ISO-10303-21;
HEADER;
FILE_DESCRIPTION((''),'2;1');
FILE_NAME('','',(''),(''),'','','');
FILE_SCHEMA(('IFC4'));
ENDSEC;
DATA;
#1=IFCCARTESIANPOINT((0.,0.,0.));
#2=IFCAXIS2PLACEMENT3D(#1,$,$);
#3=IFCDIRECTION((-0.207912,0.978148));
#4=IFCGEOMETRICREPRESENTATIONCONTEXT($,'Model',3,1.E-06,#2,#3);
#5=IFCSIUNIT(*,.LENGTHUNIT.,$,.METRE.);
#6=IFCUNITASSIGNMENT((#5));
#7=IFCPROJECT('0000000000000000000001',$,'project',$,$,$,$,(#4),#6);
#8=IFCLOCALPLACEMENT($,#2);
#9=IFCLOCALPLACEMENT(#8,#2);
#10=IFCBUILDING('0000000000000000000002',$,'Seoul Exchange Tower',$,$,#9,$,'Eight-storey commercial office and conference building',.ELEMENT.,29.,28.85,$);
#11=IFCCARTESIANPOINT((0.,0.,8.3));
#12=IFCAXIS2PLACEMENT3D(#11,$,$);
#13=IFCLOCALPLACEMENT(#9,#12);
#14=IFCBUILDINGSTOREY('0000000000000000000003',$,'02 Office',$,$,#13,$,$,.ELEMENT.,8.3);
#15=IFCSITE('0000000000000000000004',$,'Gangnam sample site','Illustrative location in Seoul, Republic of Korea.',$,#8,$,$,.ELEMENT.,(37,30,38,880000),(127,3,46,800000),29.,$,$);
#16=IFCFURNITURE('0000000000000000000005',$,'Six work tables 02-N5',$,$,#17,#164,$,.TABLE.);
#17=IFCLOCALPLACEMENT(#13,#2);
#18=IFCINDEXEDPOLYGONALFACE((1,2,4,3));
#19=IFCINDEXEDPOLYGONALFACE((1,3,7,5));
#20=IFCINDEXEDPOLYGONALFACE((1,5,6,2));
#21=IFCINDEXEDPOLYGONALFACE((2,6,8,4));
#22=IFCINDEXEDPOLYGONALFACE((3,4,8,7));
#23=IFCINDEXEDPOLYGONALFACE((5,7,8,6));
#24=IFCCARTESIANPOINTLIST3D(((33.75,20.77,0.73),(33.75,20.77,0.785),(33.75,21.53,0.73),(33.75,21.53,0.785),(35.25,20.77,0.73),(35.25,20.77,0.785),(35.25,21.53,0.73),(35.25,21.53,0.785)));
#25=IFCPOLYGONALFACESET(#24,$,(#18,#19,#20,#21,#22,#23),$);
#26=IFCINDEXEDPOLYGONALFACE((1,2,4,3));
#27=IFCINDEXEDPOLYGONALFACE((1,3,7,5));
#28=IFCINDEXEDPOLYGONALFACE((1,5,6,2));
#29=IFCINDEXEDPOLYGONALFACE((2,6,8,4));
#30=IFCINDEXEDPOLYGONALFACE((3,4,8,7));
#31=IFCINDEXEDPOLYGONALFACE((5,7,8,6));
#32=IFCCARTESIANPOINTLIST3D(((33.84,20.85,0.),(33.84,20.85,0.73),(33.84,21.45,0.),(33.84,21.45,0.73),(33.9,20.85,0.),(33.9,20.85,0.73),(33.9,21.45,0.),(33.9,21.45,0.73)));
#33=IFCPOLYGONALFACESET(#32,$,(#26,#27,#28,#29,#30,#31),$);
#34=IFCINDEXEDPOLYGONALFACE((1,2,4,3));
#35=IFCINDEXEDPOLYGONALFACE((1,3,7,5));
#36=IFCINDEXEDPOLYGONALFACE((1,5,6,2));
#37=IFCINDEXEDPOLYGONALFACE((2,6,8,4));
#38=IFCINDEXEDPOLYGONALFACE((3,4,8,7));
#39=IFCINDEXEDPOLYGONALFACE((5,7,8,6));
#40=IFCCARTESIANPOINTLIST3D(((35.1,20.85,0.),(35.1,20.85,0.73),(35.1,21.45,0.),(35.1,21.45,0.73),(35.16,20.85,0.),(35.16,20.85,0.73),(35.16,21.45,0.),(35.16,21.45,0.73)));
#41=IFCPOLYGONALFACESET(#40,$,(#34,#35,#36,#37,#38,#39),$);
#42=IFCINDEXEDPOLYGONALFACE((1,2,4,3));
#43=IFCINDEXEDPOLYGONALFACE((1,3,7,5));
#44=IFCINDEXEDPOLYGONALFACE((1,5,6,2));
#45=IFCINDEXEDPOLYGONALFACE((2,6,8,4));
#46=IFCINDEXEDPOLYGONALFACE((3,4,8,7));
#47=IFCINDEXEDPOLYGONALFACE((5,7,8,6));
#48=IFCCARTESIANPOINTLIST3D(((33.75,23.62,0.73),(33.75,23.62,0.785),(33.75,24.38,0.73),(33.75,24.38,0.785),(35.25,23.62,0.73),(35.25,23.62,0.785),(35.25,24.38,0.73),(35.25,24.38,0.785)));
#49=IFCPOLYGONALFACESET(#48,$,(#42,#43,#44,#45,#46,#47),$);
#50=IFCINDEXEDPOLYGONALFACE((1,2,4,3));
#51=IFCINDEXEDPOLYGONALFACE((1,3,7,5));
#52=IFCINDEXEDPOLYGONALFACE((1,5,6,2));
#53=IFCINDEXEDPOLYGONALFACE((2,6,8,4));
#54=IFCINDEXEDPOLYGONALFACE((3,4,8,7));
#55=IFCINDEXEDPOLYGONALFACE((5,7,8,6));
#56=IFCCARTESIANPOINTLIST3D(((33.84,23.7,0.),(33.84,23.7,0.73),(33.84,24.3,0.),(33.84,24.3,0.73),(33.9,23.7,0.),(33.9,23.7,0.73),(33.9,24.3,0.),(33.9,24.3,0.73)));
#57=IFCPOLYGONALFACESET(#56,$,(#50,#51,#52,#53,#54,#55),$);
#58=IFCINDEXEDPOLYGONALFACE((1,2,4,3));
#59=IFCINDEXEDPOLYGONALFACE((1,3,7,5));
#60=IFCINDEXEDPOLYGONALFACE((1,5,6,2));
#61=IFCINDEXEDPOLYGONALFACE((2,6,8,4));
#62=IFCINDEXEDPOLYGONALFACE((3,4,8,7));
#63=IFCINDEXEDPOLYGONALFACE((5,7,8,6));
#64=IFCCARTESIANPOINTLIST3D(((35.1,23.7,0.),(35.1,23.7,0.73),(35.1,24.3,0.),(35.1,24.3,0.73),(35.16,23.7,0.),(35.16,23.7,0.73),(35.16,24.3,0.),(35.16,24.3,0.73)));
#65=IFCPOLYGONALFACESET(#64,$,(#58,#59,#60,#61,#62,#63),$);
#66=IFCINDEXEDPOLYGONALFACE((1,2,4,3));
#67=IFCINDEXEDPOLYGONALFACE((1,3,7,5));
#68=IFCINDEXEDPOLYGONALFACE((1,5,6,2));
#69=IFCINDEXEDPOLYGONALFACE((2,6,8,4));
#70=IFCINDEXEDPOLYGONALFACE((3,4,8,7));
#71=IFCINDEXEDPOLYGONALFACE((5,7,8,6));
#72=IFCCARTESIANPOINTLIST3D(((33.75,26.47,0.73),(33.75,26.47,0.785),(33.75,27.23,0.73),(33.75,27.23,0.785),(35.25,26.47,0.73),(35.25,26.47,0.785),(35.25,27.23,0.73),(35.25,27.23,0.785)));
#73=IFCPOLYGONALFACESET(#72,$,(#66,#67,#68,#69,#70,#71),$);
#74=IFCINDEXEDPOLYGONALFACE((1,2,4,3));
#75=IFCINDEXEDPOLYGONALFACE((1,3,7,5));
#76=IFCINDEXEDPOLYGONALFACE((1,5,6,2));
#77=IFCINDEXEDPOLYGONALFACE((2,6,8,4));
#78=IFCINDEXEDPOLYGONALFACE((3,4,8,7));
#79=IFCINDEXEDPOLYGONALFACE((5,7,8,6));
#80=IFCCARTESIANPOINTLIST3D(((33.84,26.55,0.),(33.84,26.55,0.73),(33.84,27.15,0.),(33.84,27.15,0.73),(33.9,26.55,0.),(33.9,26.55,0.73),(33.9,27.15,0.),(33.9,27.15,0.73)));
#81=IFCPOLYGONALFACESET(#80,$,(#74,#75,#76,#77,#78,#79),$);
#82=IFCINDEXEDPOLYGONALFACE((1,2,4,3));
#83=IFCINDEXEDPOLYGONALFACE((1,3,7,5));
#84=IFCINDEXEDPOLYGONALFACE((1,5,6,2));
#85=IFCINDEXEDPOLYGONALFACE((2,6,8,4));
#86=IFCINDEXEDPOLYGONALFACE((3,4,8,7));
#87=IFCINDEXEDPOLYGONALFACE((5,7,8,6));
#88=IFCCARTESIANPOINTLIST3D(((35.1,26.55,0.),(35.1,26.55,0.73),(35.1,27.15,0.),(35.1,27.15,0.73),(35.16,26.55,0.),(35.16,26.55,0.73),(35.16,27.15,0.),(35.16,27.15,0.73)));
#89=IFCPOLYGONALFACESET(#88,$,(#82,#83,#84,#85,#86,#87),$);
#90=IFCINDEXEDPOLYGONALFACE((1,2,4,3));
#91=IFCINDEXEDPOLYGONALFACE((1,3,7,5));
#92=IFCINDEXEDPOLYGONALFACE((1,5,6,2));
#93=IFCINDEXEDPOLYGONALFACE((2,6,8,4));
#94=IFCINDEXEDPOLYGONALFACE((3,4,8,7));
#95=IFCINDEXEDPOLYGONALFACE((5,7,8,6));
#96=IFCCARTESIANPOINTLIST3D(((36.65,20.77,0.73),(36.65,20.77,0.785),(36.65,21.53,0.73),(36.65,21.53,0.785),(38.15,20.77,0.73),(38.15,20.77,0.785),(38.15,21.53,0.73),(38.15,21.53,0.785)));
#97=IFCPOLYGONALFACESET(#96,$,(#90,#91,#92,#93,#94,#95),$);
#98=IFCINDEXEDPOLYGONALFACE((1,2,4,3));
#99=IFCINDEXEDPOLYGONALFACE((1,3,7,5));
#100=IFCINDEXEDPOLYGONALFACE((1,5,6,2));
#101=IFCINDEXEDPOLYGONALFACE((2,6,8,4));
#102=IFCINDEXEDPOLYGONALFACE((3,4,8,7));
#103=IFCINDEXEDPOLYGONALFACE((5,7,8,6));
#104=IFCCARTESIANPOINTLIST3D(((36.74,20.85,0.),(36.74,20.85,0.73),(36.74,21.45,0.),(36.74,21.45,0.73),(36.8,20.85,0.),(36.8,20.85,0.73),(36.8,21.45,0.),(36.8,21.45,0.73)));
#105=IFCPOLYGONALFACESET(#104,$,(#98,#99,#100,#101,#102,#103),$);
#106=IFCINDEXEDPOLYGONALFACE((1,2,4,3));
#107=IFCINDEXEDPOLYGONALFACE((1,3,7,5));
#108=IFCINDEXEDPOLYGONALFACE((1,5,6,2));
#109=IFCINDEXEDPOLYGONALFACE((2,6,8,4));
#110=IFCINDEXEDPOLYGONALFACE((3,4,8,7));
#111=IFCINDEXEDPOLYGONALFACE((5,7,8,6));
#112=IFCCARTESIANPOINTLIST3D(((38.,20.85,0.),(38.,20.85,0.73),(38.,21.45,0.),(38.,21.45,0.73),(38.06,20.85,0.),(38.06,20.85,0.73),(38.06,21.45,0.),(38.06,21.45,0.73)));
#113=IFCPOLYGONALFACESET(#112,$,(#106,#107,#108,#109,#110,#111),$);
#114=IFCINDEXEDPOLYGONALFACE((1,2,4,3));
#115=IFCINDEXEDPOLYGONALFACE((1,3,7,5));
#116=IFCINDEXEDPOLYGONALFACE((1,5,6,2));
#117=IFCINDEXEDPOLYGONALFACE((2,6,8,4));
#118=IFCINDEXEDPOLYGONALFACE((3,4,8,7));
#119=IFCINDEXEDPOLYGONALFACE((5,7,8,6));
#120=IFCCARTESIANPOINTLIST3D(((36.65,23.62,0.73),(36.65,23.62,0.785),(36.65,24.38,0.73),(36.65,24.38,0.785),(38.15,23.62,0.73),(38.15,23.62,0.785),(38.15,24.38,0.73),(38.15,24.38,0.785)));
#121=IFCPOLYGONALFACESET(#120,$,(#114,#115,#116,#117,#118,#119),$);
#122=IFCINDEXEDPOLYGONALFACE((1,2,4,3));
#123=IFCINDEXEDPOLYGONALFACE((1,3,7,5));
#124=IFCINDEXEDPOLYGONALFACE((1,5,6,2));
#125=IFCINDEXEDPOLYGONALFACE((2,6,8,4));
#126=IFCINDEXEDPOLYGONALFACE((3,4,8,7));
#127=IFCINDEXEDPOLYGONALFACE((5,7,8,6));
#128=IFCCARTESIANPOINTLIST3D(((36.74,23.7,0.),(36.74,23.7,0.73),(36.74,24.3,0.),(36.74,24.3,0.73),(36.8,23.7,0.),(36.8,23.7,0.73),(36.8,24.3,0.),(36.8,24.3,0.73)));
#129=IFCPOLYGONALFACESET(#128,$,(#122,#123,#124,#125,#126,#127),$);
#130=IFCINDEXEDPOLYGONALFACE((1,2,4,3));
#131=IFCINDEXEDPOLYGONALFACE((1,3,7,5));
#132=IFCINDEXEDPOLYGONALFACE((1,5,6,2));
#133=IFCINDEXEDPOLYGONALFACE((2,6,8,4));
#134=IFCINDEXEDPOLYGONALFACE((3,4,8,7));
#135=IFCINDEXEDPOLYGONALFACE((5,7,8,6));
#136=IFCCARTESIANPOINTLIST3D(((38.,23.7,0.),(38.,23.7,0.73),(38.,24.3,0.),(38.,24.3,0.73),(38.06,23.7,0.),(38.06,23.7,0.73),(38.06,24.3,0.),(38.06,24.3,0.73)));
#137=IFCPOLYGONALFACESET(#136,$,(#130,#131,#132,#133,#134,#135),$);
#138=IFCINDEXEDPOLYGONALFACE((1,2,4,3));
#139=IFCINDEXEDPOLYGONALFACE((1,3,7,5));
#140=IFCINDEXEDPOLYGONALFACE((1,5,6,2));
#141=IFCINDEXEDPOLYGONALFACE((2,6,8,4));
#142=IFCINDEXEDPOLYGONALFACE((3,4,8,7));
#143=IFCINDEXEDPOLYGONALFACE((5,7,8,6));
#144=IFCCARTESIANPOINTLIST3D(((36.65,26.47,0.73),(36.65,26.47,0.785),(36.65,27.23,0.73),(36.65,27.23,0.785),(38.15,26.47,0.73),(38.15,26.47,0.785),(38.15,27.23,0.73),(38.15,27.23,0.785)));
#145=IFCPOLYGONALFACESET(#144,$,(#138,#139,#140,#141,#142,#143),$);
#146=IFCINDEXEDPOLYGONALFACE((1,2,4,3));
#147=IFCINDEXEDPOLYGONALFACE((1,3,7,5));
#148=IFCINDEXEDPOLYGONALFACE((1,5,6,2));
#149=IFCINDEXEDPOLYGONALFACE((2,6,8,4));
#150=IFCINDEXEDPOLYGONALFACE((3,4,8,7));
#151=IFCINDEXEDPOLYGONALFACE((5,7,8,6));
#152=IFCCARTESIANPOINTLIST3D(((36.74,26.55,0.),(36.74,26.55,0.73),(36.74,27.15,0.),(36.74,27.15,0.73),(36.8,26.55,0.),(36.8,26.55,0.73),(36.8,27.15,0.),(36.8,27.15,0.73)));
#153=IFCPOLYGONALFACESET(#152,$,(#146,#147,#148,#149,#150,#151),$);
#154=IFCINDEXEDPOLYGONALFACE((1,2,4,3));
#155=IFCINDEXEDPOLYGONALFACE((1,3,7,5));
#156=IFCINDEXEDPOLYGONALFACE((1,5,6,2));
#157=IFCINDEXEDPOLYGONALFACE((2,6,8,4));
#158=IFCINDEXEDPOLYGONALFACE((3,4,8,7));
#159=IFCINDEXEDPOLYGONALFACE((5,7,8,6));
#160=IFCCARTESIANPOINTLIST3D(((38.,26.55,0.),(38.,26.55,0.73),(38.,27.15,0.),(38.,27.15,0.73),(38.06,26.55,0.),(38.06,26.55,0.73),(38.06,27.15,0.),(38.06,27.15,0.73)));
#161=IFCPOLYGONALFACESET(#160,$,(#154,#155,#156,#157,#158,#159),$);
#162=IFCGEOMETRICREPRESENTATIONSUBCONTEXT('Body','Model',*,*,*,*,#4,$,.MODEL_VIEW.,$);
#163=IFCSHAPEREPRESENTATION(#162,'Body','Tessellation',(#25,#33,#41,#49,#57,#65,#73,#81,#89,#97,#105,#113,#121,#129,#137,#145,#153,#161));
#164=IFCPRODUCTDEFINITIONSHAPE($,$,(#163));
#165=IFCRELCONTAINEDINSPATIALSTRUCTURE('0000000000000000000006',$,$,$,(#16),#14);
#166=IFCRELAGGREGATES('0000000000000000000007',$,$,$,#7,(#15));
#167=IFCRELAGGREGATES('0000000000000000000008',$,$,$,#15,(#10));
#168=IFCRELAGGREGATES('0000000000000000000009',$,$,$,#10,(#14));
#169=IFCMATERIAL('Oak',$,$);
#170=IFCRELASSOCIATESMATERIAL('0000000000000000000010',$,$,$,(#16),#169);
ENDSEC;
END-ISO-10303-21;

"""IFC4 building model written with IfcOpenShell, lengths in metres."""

from ifc_helpers import new_model, si_unit, direction, frame, frame_2d, origin, place, context, subcontext, project, spatial, rectangle, extrude, material, element, save


model = new_model("IFC4")

# Units and contexts
model_context = context("Model", 3, precision=1e-06, world=origin(), true_north=direction((-0.207912, 0.978148)))
body_context = subcontext(model_context, "Body", "Model", "MODEL_VIEW")
ifc_project = project(units=[si_unit("LENGTHUNIT", "METRE")], contexts=[model_context])

# Site, building, storey
site_placement = place(None, origin())
site = spatial("IfcSite", under=ifc_project, at=site_placement, Name="Gangnam sample site", Description="Illustrative location in Seoul, Republic of Korea.", CompositionType="ELEMENT", RefLatitude=(37, 30, 38, 880000), RefLongitude=(127, 3, 46, 800000), RefElevation=29.0)
building_placement = place(site_placement, origin())
building = spatial("IfcBuilding", under=site, at=building_placement, Name="Seoul Exchange Tower", LongName="Eight-storey commercial office and conference building", CompositionType="ELEMENT", ElevationOfRefHeight=29.0, ElevationOfTerrain=28.85)
storey_placement = place(building_placement, frame((0.0, 0.0, 8.3)))
storey = spatial("IfcBuildingStorey", under=building, at=storey_placement, Name="02 Office", CompositionType="ELEMENT", Elevation=8.3)

# Shared definitions
placement_1 = place(storey_placement, origin())

# Furniture
ifc_material_1 = material(Name="Oak")
element("IfcFurniture", 1, at=placement_1, inside=storey, material=ifc_material_1, Name="Six work tables 02-N5", PredefinedType="TABLE", context=body_context, shape_type="SweptSolid", body=[
    extrude(rectangle(XDim=1.5, YDim=0.76, at=frame_2d((0.75, 0.38))), frame((33.75, 20.77, 0.73)), (0.0, 0.0, 1.0), 0.055),
    extrude(rectangle(XDim=0.06, YDim=0.6, at=frame_2d((0.03, 0.3))), frame((33.84, 20.85, 0.0)), (0.0, 0.0, 1.0), 0.73),
    extrude(rectangle(XDim=0.06, YDim=0.6, at=frame_2d((0.03, 0.3))), frame((35.1, 20.85, 0.0)), (0.0, 0.0, 1.0), 0.73),
    extrude(rectangle(XDim=1.5, YDim=0.76, at=frame_2d((0.75, 0.38))), frame((33.75, 23.62, 0.73)), (0.0, 0.0, 1.0), 0.055),
    extrude(rectangle(XDim=0.06, YDim=0.6, at=frame_2d((0.03, 0.3))), frame((33.84, 23.7, 0.0)), (0.0, 0.0, 1.0), 0.73),
    extrude(rectangle(XDim=0.06, YDim=0.6, at=frame_2d((0.03, 0.3))), frame((35.1, 23.7, 0.0)), (0.0, 0.0, 1.0), 0.73),
    extrude(rectangle(XDim=1.5, YDim=0.76, at=frame_2d((0.75, 0.38))), frame((33.75, 26.47, 0.73)), (0.0, 0.0, 1.0), 0.055),
    extrude(rectangle(XDim=0.06, YDim=0.6, at=frame_2d((0.03, 0.3))), frame((33.84, 26.55, 0.0)), (0.0, 0.0, 1.0), 0.73),
    extrude(rectangle(XDim=0.06, YDim=0.6, at=frame_2d((0.03, 0.3))), frame((35.1, 26.55, 0.0)), (0.0, 0.0, 1.0), 0.73),
    extrude(rectangle(XDim=1.5, YDim=0.76, at=frame_2d((0.75, 0.38))), frame((36.65, 20.77, 0.73)), (0.0, 0.0, 1.0), 0.055),
    extrude(rectangle(XDim=0.06, YDim=0.6, at=frame_2d((0.03, 0.3))), frame((36.74, 20.85, 0.0)), (0.0, 0.0, 1.0), 0.73),
    extrude(rectangle(XDim=0.06, YDim=0.6, at=frame_2d((0.03, 0.3))), frame((38.0, 20.85, 0.0)), (0.0, 0.0, 1.0), 0.73),
    extrude(rectangle(XDim=1.5, YDim=0.76, at=frame_2d((0.75, 0.38))), frame((36.65, 23.62, 0.73)), (0.0, 0.0, 1.0), 0.055),
    extrude(rectangle(XDim=0.06, YDim=0.6, at=frame_2d((0.03, 0.3))), frame((36.74, 23.7, 0.0)), (0.0, 0.0, 1.0), 0.73),
    extrude(rectangle(XDim=0.06, YDim=0.6, at=frame_2d((0.03, 0.3))), frame((38.0, 23.7, 0.0)), (0.0, 0.0, 1.0), 0.73),
    extrude(rectangle(XDim=1.5, YDim=0.76, at=frame_2d((0.75, 0.38))), frame((36.65, 26.47, 0.73)), (0.0, 0.0, 1.0), 0.055),
    extrude(rectangle(XDim=0.06, YDim=0.6, at=frame_2d((0.03, 0.3))), frame((36.74, 26.55, 0.0)), (0.0, 0.0, 1.0), 0.73),
    extrude(rectangle(XDim=0.06, YDim=0.6, at=frame_2d((0.03, 0.3))), frame((38.0, 26.55, 0.0)), (0.0, 0.0, 1.0), 0.73),
])

save(model, "model.ifc")
